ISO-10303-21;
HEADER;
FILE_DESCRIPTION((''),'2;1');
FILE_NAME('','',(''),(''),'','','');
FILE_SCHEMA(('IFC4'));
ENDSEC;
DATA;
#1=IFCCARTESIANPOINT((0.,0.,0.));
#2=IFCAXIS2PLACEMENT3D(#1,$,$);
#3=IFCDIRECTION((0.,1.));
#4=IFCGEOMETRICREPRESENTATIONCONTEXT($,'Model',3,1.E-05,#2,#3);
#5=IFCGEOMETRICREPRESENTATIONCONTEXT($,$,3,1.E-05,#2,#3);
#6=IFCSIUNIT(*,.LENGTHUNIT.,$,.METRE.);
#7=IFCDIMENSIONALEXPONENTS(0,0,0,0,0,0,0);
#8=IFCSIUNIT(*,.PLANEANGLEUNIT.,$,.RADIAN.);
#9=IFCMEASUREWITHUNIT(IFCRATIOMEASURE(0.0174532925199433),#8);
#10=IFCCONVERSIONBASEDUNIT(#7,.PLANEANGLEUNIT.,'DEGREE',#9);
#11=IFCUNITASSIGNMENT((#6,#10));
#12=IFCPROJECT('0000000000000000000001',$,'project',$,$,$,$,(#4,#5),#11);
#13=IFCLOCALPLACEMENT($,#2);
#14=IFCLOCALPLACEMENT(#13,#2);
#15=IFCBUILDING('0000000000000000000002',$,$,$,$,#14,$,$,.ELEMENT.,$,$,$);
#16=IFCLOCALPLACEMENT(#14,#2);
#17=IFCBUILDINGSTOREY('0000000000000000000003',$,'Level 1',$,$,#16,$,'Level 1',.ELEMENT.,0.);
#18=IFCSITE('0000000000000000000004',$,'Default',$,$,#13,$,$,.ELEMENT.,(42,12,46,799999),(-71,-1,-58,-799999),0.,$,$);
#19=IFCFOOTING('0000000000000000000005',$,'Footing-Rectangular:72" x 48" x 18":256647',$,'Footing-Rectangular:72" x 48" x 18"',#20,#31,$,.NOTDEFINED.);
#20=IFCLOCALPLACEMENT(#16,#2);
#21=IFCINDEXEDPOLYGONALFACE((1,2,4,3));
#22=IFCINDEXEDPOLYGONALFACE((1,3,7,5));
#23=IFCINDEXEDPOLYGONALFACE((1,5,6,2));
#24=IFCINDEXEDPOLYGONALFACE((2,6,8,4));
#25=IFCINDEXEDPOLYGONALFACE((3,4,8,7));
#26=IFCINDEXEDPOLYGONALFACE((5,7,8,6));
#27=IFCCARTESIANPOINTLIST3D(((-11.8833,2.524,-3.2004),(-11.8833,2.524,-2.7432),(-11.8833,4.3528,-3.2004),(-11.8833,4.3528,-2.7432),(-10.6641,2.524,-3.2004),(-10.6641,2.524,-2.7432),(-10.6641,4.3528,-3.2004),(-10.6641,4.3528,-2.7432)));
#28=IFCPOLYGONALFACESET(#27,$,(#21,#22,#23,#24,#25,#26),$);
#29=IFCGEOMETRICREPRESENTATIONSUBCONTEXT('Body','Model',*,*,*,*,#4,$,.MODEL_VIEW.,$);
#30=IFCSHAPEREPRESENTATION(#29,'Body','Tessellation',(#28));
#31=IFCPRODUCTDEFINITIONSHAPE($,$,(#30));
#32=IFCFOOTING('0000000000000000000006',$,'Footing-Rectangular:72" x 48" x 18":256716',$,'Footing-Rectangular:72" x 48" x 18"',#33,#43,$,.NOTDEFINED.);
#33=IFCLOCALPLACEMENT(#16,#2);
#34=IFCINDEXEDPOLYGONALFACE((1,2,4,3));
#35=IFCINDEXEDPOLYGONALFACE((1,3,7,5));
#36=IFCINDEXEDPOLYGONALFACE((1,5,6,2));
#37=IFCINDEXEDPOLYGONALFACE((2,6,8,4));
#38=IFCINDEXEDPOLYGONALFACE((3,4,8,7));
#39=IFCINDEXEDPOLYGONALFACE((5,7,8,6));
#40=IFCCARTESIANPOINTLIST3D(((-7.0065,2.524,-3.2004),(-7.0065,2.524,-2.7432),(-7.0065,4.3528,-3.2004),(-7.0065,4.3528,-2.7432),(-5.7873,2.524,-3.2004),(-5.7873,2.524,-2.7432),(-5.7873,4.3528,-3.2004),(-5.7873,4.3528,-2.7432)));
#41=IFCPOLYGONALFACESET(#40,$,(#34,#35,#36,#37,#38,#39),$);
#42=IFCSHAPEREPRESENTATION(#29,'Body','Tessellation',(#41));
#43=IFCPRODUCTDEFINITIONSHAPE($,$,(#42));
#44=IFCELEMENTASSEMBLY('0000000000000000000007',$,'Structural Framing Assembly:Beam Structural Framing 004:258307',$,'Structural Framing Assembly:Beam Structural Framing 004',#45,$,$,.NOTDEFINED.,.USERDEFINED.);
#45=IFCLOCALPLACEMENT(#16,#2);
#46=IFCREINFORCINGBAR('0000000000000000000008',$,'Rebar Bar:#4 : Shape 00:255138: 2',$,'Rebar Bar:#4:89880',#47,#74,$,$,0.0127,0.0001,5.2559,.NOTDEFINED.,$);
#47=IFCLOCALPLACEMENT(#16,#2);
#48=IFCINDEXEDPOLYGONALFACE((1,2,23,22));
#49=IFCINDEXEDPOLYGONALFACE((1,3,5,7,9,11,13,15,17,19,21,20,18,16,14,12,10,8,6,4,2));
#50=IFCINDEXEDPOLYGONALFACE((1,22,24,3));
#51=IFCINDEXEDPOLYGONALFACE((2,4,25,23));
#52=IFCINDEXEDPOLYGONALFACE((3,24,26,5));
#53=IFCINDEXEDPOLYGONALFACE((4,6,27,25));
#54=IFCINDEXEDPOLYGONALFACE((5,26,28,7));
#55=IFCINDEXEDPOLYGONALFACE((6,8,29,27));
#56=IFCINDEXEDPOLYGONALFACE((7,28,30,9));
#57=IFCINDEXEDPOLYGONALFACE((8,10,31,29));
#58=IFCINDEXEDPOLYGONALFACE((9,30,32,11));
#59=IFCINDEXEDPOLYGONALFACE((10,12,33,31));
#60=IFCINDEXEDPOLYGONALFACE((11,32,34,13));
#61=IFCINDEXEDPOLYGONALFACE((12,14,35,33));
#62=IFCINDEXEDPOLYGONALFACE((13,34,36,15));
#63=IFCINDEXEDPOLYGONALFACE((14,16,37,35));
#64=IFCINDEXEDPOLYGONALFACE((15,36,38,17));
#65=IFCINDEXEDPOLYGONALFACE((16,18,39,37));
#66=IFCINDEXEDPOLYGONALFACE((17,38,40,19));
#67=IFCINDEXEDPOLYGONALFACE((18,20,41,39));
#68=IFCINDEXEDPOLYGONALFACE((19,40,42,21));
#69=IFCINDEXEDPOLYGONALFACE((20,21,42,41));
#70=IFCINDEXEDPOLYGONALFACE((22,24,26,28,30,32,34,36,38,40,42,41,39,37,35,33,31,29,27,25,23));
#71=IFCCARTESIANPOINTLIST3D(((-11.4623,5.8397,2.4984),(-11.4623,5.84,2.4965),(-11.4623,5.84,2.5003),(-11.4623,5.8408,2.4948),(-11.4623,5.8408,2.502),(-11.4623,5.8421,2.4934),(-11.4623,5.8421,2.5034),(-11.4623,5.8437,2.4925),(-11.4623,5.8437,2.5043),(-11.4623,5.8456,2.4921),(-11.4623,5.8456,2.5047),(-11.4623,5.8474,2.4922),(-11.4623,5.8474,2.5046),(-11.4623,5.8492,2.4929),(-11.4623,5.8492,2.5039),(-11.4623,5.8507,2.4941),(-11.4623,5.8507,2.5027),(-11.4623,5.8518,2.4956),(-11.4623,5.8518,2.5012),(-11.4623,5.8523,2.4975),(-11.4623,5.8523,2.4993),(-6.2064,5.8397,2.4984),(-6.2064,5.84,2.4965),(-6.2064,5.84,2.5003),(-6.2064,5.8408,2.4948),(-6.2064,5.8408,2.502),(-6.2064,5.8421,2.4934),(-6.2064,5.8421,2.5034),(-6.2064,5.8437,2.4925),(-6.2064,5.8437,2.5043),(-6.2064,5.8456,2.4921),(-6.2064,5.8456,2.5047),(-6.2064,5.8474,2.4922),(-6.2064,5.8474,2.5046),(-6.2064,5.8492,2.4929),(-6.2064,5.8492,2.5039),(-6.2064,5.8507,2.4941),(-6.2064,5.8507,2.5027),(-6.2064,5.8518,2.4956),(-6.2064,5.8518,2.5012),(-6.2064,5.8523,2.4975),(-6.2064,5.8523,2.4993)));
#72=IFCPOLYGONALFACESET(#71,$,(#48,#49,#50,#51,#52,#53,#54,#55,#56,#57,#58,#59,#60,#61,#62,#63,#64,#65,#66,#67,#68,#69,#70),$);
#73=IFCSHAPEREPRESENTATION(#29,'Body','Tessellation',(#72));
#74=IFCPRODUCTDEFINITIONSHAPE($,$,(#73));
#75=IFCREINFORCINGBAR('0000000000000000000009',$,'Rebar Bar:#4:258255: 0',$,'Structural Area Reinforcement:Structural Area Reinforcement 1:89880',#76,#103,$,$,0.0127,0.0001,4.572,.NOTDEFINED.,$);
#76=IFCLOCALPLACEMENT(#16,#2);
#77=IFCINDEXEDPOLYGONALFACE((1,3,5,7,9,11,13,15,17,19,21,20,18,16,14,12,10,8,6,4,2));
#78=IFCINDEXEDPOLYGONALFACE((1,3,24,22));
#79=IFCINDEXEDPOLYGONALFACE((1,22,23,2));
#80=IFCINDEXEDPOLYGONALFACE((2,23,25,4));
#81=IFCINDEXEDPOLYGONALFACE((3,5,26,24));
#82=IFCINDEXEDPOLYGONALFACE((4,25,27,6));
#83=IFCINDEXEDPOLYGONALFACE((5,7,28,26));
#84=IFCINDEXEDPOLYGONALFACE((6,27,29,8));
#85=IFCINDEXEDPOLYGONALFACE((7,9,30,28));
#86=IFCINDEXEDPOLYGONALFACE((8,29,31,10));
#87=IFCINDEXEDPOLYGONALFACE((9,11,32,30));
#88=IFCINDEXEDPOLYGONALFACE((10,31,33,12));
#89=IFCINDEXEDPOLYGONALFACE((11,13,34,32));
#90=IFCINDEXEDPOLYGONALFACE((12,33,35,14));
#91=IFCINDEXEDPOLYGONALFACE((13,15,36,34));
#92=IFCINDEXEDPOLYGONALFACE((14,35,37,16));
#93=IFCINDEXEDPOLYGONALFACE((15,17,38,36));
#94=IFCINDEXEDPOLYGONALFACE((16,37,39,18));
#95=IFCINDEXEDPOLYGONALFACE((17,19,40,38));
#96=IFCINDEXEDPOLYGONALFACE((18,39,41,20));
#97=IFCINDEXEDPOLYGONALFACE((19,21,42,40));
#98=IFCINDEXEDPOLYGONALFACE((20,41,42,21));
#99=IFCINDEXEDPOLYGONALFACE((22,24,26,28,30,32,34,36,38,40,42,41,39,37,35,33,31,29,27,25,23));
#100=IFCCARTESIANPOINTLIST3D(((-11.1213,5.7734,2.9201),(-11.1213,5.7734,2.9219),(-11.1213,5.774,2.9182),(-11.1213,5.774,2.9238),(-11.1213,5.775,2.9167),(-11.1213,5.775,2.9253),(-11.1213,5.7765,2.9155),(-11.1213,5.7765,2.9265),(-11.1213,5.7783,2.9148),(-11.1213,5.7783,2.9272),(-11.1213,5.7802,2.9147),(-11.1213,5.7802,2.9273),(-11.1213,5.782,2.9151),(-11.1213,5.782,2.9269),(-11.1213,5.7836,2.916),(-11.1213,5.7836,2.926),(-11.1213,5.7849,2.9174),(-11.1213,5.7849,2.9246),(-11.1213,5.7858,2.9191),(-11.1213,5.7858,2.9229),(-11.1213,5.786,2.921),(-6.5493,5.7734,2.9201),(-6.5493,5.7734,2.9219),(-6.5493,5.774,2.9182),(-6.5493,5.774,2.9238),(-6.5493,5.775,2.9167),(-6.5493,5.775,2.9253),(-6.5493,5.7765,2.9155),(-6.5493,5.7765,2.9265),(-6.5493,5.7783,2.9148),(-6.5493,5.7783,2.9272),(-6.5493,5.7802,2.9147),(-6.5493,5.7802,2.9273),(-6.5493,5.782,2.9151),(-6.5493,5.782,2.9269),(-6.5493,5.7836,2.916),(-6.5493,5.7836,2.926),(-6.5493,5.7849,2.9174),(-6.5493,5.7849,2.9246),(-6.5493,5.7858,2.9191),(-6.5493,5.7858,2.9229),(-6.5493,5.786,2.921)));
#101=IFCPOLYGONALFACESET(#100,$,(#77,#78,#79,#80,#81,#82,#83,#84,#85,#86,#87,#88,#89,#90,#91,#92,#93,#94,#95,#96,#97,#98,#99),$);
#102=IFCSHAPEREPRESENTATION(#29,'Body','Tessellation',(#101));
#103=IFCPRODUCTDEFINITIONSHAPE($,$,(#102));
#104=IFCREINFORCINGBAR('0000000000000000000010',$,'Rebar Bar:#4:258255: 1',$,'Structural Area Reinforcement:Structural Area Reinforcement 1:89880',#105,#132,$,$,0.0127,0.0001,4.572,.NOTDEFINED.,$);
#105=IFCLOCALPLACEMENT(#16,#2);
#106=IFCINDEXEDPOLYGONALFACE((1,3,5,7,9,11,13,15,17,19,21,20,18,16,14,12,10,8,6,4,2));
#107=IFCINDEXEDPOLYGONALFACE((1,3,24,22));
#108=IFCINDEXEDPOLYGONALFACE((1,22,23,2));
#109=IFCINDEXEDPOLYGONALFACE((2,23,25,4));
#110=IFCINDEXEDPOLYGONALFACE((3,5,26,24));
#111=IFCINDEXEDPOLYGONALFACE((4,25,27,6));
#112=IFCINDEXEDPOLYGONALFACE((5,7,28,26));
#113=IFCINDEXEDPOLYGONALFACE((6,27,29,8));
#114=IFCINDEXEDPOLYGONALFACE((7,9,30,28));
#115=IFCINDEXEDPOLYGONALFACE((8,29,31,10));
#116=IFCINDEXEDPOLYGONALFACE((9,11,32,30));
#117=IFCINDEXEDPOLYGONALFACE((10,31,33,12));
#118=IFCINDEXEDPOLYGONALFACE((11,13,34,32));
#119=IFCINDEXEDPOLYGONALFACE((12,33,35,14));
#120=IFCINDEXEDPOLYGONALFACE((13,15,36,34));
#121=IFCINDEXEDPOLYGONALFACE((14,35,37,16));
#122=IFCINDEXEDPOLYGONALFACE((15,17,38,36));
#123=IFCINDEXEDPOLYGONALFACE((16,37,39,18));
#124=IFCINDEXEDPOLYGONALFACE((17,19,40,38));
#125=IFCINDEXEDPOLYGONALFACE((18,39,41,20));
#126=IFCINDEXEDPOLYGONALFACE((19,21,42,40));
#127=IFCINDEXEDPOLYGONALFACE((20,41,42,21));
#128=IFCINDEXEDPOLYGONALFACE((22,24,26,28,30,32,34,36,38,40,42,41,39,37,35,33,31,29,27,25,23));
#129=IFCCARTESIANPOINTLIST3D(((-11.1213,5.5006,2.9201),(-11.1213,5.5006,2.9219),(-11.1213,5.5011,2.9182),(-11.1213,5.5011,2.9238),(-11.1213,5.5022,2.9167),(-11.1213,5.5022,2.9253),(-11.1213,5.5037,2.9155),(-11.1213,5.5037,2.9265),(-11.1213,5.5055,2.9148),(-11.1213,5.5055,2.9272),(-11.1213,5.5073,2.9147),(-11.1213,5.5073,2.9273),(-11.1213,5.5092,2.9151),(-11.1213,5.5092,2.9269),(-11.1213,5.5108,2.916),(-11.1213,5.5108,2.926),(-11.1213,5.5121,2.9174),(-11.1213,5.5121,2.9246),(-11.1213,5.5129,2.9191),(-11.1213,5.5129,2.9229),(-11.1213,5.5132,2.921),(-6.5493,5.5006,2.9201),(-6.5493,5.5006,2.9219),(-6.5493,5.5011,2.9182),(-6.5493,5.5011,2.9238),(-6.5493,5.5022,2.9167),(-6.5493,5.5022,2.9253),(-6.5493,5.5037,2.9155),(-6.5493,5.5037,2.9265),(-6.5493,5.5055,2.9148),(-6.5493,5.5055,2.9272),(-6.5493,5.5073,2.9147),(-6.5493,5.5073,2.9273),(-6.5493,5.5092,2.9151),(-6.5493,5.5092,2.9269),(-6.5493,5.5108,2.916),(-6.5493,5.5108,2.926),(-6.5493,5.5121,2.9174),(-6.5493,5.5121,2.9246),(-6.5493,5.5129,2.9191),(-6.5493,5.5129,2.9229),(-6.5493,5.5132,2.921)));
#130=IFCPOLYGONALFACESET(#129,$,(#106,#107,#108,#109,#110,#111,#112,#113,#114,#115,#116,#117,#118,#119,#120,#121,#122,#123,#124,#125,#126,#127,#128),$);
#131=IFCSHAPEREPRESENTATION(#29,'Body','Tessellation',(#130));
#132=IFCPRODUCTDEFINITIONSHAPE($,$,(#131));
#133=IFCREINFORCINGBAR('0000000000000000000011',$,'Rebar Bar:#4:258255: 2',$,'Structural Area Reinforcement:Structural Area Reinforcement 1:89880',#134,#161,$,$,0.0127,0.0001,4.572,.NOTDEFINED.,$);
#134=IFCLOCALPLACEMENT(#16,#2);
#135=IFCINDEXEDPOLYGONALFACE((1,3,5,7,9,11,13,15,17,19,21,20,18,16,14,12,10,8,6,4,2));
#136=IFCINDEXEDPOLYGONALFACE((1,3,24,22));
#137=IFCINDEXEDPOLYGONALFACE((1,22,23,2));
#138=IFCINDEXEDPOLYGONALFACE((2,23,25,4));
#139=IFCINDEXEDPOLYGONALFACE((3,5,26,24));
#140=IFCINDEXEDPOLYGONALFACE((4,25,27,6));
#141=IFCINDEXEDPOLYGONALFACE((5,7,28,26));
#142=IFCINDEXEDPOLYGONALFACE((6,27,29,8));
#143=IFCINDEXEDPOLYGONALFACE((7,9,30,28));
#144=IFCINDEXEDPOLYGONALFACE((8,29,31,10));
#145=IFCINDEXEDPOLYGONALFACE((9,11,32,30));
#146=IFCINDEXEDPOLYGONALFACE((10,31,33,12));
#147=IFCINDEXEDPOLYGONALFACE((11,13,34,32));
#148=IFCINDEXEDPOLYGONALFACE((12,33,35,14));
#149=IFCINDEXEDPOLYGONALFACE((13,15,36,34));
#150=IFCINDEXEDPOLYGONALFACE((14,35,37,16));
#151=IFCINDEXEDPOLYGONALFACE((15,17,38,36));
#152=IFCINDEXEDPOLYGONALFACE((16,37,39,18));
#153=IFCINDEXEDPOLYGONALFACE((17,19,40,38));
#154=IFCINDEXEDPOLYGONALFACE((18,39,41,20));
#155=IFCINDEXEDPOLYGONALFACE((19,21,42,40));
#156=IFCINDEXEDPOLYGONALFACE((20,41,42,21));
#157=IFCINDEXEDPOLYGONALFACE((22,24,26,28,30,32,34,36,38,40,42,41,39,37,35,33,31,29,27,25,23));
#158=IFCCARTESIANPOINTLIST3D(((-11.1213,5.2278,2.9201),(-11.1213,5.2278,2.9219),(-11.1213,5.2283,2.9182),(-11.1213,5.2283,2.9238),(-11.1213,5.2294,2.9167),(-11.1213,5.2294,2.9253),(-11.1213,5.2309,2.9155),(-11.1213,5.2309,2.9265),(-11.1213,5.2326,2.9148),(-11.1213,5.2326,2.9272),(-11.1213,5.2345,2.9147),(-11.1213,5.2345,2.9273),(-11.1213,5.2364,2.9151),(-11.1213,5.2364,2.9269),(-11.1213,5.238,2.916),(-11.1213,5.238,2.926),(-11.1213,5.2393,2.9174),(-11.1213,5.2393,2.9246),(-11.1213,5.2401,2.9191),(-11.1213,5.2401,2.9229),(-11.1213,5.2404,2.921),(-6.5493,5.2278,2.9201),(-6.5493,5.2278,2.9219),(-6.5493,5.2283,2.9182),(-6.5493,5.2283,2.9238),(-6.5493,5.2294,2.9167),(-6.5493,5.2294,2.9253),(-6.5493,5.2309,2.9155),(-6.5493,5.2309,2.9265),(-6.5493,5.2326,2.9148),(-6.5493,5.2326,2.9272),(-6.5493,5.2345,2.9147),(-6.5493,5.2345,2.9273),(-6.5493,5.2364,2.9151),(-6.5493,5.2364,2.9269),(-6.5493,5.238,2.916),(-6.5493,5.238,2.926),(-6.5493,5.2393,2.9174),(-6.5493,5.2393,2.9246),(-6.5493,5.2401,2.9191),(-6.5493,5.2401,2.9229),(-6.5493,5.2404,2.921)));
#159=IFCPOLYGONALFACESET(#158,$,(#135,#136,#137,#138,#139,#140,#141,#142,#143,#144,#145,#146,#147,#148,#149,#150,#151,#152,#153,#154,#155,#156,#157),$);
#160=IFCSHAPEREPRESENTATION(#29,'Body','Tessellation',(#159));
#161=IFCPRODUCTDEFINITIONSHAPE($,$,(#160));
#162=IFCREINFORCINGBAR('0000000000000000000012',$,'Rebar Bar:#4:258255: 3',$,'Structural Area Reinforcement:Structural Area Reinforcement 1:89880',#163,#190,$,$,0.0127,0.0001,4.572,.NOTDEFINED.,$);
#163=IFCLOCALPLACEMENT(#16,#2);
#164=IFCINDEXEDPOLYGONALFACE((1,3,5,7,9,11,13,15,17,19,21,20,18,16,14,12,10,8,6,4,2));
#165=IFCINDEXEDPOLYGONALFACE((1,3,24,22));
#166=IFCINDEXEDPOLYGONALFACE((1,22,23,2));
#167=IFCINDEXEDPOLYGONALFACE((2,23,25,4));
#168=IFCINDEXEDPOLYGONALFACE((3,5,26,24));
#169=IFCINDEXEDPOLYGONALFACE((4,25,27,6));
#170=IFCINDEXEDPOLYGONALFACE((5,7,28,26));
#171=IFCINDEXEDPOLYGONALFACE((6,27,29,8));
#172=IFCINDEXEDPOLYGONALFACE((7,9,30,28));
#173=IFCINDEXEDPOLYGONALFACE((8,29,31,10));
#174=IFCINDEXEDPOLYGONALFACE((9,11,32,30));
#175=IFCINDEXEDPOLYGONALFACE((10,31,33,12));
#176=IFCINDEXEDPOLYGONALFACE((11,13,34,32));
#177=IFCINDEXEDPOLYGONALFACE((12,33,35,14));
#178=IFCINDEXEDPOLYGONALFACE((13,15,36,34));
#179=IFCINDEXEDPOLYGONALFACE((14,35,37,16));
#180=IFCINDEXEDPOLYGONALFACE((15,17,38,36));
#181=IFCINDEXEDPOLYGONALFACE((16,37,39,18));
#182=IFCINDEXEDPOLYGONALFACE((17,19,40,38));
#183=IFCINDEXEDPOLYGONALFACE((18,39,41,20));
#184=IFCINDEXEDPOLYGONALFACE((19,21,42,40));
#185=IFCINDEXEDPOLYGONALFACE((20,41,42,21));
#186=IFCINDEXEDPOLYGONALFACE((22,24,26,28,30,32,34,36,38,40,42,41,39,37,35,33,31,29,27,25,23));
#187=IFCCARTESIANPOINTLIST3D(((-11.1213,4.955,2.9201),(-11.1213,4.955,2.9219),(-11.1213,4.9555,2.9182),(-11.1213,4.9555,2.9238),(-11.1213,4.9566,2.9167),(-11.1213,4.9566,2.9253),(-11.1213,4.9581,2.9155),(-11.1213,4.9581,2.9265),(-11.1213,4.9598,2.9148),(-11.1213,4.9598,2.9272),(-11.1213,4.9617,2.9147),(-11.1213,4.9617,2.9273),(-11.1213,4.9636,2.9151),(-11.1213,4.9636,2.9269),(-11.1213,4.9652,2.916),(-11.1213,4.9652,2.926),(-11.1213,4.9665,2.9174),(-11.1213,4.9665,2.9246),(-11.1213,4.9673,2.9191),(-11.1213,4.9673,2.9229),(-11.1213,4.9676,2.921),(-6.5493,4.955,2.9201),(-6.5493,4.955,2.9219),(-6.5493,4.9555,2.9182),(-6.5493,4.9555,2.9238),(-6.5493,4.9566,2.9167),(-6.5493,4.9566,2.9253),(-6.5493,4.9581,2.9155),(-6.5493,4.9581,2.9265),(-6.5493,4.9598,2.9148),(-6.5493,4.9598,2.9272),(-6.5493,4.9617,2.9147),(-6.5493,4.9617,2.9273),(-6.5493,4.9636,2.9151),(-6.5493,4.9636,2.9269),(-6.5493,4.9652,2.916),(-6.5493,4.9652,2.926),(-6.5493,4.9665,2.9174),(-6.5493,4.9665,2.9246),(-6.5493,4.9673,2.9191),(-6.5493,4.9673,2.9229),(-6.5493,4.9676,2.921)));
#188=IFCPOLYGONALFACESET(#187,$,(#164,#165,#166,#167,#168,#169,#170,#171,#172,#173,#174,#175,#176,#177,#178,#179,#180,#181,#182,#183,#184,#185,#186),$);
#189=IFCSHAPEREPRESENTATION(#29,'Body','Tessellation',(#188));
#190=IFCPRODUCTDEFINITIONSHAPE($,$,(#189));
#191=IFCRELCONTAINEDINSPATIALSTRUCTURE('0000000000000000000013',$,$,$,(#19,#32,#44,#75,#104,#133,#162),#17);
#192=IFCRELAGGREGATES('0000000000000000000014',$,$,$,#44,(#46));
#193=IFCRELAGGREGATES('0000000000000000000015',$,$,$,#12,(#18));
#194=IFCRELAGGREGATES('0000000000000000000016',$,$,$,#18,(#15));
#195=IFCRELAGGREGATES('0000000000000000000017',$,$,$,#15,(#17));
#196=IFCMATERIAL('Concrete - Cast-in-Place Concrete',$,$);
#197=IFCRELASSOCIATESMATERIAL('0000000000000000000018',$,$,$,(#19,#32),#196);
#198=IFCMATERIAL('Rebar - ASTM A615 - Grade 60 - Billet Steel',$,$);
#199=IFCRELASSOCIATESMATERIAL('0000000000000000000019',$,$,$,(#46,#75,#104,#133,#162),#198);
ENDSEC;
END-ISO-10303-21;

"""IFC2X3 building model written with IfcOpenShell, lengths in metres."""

from ifc_helpers import new_model, entity, si_unit, converted_unit, direction, frame, frame_2d, origin, origin_2d_with_axis, place, context, subcontext, project, spatial, rectangle, extrude, material, element, aggregate, save


model = new_model("IFC2X3")

# Units and contexts
model_context = context("Model", 3, precision=1e-05, world=origin(), true_north=direction((0.0, 1.0)))
context_of_model = context(None, 3, precision=1e-05, world=origin(), true_north=direction((0.0, 1.0)))
body_context = subcontext(model_context, "Body", "Model", "MODEL_VIEW")
ifc_project = project(units=[si_unit("LENGTHUNIT", "METRE"), converted_unit("PLANEANGLEUNIT", "DEGREE", entity("IfcRatioMeasure", 0.0174532925199433), si_unit("PLANEANGLEUNIT", "RADIAN"), dimensions=[0, 0, 0, 0, 0, 0, 0])], contexts=[model_context, context_of_model])

# Site, building, storey
site_placement = place(None, origin())
site = spatial("IfcSite", under=ifc_project, at=site_placement, Name="Default", CompositionType="ELEMENT", RefLatitude=(42, 12, 46, 799999), RefLongitude=(-71, -1, -58, -799999), RefElevation=0.0)
building_placement = place(site_placement, origin())
building = spatial("IfcBuilding", under=site, at=building_placement, CompositionType="ELEMENT")
storey_placement = place(building_placement, origin())
storey = spatial("IfcBuildingStorey", under=building, at=storey_placement, Name="Level 1", LongName="Level 1", CompositionType="ELEMENT", Elevation=0.0)

# Footings
ifc_material_1 = material(Name="Concrete - Cast-in-Place Concrete")
footing_1_placement = place(storey_placement, origin())
element("IfcFooting", 1, at=footing_1_placement, inside=storey, material=ifc_material_1, Name="Footing-Rectangular:72\" x 48\" x 18\":256647", ObjectType="Footing-Rectangular:72\" x 48\" x 18\"", PredefinedType="NOTDEFINED", context=body_context, shape_type="SweptSolid", body=[
    extrude(rectangle(XDim=1.2192, YDim=1.8288, at=origin_2d_with_axis()), frame((-11.2737, 3.4384, -3.2004), z_axis=(0.0, 0.0, 1.0), x_axis=(-1.0, 0.0, 0.0)), (0.0, 0.0, 1.0), 0.4572),
])
footing_2_placement = place(storey_placement, origin())
element("IfcFooting", 2, at=footing_2_placement, inside=storey, material=ifc_material_1, Name="Footing-Rectangular:72\" x 48\" x 18\":256716", ObjectType="Footing-Rectangular:72\" x 48\" x 18\"", PredefinedType="NOTDEFINED", context=body_context, shape_type="SweptSolid", body=[
    extrude(rectangle(XDim=1.2192, YDim=1.8288, at=frame_2d((0.0, 0.0), x_axis=(1.0, 0.0))), frame((-6.3969, 3.4384, -3.2004), z_axis=(0.0, 0.0, 1.0), x_axis=(-1.0, 0.0, 0.0)), (0.0, 0.0, 1.0), 0.4572),
])

# Element assembly, reinforcing bar
assembly_placement = place(storey_placement, origin())
assembly = element("IfcElementAssembly", 3, at=assembly_placement, inside=storey, Name="Structural Framing Assembly:Beam Structural Framing 004:258307", ObjectType="Structural Framing Assembly:Beam Structural Framing 004", AssemblyPlace="NOTDEFINED", PredefinedType="USERDEFINED")
ifc_material_2 = material(Name="Rebar - ASTM A615 - Grade 60 - Billet Steel")
reinforcing_bar_1_placement = place(assembly_placement, origin())
reinforcing_bar_1 = element("IfcReinforcingBar", 4, at=reinforcing_bar_1_placement, material=ifc_material_2, Name="Rebar Bar:#4 : Shape 00:255138: 2", ObjectType="Rebar Bar:#4:89880", BarLength=5.2559, BarRole="NOTDEFINED", CrossSectionArea=0.0001, NominalDiameter=0.0127, context=body_context, shape_type="AdvancedSweptSolid", body=[
    entity("IfcSweptDiskSolid", entity("IfcCompositeCurve", [entity("IfcCompositeCurveSegment", "CONTINUOUS", True, entity("IfcPolyline", [entity("IfcCartesianPoint", [-6.2064, 5.846, 2.4984]), entity("IfcCartesianPoint", [-11.4623, 5.846, 2.4984])]))], False), 0.0063, None, 0.0, 1.0),
])
aggregate(assembly, [reinforcing_bar_1])

# Reinforcing bars
reinforcing_bar_2_placement = place(storey_placement, origin())
element("IfcReinforcingBar", 5, at=reinforcing_bar_2_placement, inside=storey, material=ifc_material_2, Name="Rebar Bar:#4:258255: 0", ObjectType="Structural Area Reinforcement:Structural Area Reinforcement 1:89880", BarLength=4.572, BarRole="NOTDEFINED", CrossSectionArea=0.0001, NominalDiameter=0.0127, context=body_context, shape_type="AdvancedSweptSolid", body=[
    entity("IfcSweptDiskSolid", entity("IfcCompositeCurve", [entity("IfcCompositeCurveSegment", "CONTINUOUS", True, entity("IfcPolyline", [entity("IfcCartesianPoint", [-11.1213, 5.7797, 2.921]), entity("IfcCartesianPoint", [-6.5493, 5.7797, 2.921])]))], False), 0.0063, None, 0.0, 1.0),
])
reinforcing_bar_3_placement = place(storey_placement, origin())
element("IfcReinforcingBar", 6, at=reinforcing_bar_3_placement, inside=storey, material=ifc_material_2, Name="Rebar Bar:#4:258255: 1", ObjectType="Structural Area Reinforcement:Structural Area Reinforcement 1:89880", BarLength=4.572, BarRole="NOTDEFINED", CrossSectionArea=0.0001, NominalDiameter=0.0127, context=body_context, shape_type="AdvancedSweptSolid", body=[
    entity("IfcSweptDiskSolid", entity("IfcCompositeCurve", [entity("IfcCompositeCurveSegment", "CONTINUOUS", True, entity("IfcPolyline", [entity("IfcCartesianPoint", [-11.1213, 5.5069, 2.921]), entity("IfcCartesianPoint", [-6.5493, 5.5069, 2.921])]))], False), 0.0063, None, 0.0, 1.0),
])
reinforcing_bar_4_placement = place(storey_placement, origin())
element("IfcReinforcingBar", 7, at=reinforcing_bar_4_placement, inside=storey, material=ifc_material_2, Name="Rebar Bar:#4:258255: 2", ObjectType="Structural Area Reinforcement:Structural Area Reinforcement 1:89880", BarLength=4.572, BarRole="NOTDEFINED", CrossSectionArea=0.0001, NominalDiameter=0.0127, context=body_context, shape_type="AdvancedSweptSolid", body=[
    entity("IfcSweptDiskSolid", entity("IfcCompositeCurve", [entity("IfcCompositeCurveSegment", "CONTINUOUS", True, entity("IfcPolyline", [entity("IfcCartesianPoint", [-11.1213, 5.2341, 2.921]), entity("IfcCartesianPoint", [-6.5493, 5.2341, 2.921])]))], False), 0.0063, None, 0.0, 1.0),
])
reinforcing_bar_5_placement = place(storey_placement, origin())
element("IfcReinforcingBar", 8, at=reinforcing_bar_5_placement, inside=storey, material=ifc_material_2, Name="Rebar Bar:#4:258255: 3", ObjectType="Structural Area Reinforcement:Structural Area Reinforcement 1:89880", BarLength=4.572, BarRole="NOTDEFINED", CrossSectionArea=0.0001, NominalDiameter=0.0127, context=body_context, shape_type="AdvancedSweptSolid", body=[
    entity("IfcSweptDiskSolid", entity("IfcCompositeCurve", [entity("IfcCompositeCurveSegment", "CONTINUOUS", True, entity("IfcPolyline", [entity("IfcCartesianPoint", [-11.1213, 4.9612, 2.921]), entity("IfcCartesianPoint", [-6.5493, 4.9612, 2.921])]))], False), 0.0063, None, 0.0, 1.0),
])

save(model, "model.ifc")
